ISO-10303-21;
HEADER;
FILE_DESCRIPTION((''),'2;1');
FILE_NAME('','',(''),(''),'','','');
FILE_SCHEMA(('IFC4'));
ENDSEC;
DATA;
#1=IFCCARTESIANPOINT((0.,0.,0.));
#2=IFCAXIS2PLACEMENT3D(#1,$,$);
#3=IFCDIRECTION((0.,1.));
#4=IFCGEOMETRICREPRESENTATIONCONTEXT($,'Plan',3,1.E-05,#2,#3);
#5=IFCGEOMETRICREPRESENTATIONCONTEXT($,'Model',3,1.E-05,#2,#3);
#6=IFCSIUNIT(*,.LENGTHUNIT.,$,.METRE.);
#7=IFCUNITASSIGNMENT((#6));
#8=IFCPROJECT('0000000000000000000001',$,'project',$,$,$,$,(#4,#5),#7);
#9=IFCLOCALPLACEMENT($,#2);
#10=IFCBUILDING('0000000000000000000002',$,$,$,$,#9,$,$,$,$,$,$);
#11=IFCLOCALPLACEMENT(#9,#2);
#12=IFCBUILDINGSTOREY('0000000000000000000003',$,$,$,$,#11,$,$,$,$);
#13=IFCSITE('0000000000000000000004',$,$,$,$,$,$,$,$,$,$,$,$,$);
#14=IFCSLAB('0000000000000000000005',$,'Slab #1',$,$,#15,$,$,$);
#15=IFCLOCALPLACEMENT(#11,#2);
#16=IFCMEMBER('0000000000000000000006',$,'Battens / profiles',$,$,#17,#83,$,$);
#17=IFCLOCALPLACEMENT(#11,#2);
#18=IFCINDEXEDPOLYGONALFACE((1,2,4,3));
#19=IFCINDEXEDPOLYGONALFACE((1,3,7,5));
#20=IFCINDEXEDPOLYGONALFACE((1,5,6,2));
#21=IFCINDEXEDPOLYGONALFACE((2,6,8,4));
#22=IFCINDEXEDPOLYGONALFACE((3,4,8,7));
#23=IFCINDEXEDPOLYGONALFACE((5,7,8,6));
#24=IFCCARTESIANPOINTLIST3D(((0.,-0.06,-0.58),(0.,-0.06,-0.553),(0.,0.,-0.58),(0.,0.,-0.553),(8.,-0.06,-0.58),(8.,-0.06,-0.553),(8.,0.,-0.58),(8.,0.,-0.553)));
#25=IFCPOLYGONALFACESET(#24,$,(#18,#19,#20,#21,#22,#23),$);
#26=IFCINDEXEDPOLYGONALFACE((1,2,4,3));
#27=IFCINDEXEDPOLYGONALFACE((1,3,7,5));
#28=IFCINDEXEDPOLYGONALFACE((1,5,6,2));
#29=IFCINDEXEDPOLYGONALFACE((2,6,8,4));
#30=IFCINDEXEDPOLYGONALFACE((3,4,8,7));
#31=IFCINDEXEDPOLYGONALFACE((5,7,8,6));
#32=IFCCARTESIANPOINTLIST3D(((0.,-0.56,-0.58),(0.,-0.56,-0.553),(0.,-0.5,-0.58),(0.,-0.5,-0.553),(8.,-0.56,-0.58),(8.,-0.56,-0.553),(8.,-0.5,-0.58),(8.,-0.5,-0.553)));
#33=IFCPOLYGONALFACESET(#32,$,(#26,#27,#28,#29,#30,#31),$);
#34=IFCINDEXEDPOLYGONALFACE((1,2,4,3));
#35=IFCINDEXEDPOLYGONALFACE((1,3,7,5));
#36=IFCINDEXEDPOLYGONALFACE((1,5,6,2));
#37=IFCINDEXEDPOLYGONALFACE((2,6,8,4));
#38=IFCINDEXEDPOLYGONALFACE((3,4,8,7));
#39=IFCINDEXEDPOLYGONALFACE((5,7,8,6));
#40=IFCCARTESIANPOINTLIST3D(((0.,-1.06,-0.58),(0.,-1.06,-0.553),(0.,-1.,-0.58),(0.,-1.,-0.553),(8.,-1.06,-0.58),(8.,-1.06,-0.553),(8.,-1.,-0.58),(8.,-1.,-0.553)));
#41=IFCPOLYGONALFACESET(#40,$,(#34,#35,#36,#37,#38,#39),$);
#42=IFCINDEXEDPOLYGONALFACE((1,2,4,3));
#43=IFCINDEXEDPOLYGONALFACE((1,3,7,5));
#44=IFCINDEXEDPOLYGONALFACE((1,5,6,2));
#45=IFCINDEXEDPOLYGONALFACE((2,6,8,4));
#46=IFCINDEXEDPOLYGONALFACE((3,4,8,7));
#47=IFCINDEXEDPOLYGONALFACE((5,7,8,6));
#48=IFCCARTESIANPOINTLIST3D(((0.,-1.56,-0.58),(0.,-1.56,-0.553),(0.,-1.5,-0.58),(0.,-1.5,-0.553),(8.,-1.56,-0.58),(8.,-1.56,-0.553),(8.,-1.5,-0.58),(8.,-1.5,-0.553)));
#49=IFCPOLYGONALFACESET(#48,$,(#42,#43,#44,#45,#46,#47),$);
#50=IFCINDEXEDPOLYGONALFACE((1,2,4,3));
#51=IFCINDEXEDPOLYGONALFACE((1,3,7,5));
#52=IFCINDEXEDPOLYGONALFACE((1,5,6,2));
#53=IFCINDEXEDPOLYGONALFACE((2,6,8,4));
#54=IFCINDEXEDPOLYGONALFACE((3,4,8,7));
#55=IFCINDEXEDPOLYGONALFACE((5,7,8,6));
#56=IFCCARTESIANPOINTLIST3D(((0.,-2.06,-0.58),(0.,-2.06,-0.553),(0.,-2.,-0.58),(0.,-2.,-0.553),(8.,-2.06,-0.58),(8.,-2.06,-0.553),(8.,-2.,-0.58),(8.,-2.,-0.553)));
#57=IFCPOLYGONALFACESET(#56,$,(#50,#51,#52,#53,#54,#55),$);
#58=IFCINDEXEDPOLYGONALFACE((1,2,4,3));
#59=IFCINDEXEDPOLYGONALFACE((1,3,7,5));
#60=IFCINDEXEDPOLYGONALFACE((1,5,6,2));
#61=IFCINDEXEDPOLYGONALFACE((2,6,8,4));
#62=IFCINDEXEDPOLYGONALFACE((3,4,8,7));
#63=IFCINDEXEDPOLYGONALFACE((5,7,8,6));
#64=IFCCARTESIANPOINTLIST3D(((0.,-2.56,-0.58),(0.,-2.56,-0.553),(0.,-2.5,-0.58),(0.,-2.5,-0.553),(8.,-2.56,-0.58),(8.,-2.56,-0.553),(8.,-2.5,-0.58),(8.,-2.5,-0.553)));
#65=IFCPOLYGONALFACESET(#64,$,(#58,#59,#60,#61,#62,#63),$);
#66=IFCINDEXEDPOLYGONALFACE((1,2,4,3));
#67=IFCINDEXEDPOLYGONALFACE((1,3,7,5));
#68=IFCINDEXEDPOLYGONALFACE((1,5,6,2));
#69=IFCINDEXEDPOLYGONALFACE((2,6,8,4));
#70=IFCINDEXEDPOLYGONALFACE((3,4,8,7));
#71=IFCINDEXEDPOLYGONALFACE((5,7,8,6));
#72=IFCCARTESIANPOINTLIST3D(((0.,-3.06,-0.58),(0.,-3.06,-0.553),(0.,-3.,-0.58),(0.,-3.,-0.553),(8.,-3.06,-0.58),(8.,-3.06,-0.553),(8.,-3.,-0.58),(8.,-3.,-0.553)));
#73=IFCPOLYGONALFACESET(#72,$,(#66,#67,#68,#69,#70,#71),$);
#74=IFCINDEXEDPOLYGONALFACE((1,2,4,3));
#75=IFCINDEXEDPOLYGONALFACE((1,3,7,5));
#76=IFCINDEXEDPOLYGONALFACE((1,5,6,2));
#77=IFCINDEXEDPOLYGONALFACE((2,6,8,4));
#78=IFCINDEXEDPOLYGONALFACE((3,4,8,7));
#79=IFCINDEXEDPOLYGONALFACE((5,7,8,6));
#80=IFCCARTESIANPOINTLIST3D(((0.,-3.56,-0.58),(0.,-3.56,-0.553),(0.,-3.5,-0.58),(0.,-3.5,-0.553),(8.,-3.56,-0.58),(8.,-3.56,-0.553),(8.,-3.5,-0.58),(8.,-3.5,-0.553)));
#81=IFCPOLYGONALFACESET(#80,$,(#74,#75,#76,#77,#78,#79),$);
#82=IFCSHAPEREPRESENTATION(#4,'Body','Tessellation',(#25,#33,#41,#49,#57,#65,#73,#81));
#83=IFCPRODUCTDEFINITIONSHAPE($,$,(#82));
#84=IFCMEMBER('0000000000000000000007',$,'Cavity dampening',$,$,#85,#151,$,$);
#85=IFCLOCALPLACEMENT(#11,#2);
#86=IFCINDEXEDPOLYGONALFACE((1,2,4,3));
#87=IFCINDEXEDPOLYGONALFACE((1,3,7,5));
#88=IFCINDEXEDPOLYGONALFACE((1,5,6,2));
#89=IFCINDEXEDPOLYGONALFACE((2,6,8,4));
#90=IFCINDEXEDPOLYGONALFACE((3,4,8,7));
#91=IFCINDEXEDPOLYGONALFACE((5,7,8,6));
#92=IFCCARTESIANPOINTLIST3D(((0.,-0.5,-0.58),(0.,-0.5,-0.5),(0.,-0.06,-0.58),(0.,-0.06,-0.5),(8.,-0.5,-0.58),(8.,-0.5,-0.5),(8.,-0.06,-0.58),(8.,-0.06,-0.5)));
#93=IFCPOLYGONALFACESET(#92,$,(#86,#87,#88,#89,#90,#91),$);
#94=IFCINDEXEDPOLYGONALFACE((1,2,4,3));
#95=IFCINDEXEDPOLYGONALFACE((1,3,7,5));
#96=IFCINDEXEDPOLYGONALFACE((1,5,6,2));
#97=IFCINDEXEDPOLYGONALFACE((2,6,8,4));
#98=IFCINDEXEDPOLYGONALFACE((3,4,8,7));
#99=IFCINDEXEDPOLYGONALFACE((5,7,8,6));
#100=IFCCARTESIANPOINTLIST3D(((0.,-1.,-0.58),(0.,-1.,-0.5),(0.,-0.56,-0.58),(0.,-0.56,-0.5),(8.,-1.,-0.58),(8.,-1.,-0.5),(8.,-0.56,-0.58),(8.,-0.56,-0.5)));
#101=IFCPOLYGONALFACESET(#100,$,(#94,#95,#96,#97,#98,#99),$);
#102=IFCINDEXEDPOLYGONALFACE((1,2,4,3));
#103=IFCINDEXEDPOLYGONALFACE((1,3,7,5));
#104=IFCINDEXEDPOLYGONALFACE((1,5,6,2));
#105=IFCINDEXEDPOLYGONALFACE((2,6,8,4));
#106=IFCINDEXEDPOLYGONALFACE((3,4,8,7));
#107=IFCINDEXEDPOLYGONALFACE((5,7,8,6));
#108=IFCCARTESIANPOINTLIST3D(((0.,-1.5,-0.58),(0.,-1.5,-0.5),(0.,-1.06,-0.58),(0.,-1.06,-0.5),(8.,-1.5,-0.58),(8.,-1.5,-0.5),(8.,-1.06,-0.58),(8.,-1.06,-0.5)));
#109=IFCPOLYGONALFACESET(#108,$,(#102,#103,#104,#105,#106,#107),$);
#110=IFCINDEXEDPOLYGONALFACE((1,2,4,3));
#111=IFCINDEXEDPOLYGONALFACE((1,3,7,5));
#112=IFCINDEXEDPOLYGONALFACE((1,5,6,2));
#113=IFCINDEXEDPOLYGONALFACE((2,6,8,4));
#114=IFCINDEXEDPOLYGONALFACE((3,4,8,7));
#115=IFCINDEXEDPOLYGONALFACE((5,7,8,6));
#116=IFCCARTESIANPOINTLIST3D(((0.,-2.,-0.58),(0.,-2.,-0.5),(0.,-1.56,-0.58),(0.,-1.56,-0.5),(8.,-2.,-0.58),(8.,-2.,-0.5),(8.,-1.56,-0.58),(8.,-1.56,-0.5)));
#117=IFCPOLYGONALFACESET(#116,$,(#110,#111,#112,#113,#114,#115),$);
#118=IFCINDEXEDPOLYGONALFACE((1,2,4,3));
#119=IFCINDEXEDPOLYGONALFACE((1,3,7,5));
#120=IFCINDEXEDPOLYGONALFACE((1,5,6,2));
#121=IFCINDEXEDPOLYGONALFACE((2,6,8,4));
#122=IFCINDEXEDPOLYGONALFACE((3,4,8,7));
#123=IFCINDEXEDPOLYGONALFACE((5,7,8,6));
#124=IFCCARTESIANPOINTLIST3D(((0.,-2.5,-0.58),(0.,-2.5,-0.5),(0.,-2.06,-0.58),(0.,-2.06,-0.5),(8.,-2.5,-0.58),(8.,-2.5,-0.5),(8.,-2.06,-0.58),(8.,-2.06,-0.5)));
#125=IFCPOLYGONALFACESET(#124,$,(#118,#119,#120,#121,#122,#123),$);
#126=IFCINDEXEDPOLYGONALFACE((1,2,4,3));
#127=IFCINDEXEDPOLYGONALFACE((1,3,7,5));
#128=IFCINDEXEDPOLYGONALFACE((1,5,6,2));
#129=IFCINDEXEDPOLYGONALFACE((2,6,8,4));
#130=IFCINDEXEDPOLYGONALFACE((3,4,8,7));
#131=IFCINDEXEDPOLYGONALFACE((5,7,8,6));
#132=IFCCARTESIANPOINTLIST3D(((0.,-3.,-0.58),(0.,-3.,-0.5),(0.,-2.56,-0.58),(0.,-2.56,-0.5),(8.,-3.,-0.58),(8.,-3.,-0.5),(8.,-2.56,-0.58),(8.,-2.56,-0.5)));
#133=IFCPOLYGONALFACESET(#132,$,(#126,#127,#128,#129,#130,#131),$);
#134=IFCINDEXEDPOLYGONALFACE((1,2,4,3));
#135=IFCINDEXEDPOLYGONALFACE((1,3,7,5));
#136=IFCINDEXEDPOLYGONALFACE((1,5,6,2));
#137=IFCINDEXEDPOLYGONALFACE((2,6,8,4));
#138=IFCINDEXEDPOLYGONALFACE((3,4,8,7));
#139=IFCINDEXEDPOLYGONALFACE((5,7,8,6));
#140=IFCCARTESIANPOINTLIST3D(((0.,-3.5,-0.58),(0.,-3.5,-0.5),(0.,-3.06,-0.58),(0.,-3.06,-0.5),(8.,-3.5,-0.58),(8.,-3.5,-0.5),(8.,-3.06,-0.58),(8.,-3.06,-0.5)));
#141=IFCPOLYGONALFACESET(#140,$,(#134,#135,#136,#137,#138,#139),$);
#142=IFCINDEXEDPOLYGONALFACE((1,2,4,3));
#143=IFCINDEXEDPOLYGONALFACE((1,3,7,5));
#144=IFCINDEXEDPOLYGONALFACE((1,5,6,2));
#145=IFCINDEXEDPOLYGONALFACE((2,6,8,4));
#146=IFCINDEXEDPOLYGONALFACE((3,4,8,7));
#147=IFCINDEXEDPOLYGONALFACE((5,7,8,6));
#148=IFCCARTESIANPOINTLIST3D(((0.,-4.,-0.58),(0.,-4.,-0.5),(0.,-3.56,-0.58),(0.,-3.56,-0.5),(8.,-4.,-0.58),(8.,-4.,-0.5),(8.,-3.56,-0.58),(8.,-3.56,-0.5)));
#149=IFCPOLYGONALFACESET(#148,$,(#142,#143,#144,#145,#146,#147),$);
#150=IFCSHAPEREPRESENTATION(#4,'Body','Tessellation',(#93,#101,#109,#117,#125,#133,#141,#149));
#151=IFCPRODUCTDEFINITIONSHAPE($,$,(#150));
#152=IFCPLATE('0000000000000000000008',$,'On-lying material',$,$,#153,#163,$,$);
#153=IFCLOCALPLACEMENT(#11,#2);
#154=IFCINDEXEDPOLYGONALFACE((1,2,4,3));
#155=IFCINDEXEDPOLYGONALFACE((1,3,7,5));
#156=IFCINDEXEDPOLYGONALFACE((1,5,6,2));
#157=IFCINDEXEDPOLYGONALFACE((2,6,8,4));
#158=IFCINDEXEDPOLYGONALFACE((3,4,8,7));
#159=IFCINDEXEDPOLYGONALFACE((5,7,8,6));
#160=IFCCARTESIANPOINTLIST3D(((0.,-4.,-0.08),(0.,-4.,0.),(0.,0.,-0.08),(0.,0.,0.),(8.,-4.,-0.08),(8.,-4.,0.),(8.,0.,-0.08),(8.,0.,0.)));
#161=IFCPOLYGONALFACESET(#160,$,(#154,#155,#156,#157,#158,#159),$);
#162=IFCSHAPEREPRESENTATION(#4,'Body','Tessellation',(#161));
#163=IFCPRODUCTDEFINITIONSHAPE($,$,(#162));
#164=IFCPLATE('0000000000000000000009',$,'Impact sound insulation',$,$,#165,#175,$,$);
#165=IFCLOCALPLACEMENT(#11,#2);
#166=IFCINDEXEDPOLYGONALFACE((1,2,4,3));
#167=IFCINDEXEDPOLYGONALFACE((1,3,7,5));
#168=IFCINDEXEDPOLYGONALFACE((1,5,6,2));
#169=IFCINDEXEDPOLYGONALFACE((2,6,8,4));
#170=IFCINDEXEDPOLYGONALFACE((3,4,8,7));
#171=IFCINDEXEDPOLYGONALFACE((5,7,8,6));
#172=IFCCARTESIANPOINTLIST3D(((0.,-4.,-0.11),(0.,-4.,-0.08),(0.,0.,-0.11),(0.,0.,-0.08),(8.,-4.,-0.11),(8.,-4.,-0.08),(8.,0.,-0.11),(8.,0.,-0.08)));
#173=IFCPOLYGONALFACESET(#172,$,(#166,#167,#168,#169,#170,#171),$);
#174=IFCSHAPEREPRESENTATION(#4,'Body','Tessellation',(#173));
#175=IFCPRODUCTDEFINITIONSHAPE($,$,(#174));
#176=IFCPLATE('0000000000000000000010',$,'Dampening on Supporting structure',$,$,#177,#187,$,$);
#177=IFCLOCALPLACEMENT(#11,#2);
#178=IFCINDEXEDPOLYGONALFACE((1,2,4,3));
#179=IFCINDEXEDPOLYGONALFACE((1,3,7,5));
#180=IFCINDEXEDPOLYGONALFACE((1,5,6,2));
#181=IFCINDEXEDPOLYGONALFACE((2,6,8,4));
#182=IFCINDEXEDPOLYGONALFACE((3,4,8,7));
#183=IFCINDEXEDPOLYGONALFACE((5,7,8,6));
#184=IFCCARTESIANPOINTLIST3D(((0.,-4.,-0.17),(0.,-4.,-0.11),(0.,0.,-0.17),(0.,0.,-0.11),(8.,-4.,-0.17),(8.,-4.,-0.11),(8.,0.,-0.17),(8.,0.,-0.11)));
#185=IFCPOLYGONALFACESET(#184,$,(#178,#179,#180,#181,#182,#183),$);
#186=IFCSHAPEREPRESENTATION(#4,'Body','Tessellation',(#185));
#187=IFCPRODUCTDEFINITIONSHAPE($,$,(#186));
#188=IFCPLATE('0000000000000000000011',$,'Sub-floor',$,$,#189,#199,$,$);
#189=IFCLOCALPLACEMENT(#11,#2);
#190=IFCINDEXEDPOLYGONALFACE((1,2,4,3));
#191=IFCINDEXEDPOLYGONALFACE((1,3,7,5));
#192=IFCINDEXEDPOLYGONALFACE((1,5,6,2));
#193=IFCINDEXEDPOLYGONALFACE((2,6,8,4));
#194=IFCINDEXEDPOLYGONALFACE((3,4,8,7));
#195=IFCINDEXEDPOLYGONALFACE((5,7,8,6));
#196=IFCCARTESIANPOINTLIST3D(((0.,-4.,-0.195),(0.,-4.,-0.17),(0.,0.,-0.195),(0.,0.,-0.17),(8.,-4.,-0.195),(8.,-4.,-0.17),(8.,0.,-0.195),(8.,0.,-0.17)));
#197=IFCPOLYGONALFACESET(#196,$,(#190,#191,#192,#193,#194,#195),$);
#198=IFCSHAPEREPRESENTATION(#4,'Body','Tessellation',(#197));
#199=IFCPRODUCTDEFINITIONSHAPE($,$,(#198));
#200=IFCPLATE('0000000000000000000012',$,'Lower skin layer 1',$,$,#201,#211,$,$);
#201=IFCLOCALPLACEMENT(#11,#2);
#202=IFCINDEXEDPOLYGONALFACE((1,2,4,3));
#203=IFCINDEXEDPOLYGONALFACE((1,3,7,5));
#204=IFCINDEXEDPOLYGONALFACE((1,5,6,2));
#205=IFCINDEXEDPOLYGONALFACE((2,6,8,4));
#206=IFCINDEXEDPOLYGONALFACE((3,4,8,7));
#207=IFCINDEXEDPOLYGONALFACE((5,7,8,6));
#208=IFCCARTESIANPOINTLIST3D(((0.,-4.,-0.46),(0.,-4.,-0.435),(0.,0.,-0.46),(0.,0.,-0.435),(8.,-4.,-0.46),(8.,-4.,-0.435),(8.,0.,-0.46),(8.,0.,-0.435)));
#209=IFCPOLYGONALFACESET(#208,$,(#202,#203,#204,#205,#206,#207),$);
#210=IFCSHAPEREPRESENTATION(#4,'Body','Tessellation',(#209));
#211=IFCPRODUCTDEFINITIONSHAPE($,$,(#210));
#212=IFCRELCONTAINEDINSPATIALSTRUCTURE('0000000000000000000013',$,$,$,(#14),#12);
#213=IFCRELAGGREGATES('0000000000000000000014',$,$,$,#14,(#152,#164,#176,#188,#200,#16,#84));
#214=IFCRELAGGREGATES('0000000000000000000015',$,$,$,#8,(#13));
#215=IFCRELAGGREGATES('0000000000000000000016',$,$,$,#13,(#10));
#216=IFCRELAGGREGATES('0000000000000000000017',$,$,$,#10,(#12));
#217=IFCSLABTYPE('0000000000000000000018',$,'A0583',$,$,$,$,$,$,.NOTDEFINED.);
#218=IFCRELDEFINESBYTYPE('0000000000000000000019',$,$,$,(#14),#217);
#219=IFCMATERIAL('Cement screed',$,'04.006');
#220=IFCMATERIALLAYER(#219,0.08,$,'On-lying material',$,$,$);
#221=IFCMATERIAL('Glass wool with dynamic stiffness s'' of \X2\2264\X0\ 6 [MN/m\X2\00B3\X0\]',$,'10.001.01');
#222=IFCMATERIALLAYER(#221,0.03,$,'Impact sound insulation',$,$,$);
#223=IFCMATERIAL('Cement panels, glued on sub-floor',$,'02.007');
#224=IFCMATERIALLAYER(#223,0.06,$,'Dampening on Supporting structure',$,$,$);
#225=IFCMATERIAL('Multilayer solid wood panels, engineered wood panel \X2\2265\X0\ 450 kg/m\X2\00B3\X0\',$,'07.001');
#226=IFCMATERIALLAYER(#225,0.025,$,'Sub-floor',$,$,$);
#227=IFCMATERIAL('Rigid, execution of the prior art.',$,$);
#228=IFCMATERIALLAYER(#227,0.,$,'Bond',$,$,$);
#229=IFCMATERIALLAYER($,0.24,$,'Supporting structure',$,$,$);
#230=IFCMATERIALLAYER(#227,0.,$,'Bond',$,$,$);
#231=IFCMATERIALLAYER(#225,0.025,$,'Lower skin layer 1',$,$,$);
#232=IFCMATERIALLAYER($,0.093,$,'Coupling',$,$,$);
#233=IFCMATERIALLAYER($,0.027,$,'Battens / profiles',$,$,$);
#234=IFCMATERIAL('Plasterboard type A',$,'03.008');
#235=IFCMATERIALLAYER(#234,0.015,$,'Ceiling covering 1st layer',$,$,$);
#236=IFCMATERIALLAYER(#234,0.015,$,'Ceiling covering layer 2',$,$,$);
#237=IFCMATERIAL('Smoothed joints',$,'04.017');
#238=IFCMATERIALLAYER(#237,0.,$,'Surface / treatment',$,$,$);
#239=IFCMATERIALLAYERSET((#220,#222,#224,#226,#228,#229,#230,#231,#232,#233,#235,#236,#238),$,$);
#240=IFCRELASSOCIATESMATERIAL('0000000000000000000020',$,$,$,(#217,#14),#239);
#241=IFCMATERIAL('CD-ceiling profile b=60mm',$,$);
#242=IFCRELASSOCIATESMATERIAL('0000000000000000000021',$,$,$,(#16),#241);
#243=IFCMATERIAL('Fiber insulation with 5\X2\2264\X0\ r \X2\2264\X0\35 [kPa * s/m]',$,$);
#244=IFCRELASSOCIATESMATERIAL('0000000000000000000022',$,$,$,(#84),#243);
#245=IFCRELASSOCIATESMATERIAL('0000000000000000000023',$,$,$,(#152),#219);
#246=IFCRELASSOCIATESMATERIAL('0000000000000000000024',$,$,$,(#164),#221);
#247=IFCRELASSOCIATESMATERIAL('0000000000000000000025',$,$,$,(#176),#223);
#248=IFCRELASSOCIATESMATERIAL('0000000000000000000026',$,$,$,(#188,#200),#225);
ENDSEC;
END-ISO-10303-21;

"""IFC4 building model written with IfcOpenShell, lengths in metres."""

from ifc_helpers import new_model, si_unit, direction, frame, frame_2d, origin, origin_with_axes, place, context, project, spatial, rectangle, extrude, material, layer, layer_set, type_object, element, aggregate, save


model = new_model("IFC4")

# Units and contexts
plan_context = context("Plan", 3, precision=1e-05, world=origin(), true_north=direction((0.0, 1.0)))
model_context = context("Model", 3, precision=1e-05, world=origin(), true_north=direction((0.0, 1.0)))
ifc_project = project(units=[si_unit("LENGTHUNIT", "METRE")], contexts=[plan_context, model_context])

# Site, building, storey
site = spatial("IfcSite", under=ifc_project)
building_placement = place(None, origin())
building = spatial("IfcBuilding", under=site, at=building_placement)
storey_placement = place(building_placement, origin())
storey = spatial("IfcBuildingStorey", under=building, at=storey_placement)

# Slab, members, plates
ifc_material_1 = material(Name="Cement screed", Category="04.006")
ifc_layer_1 = layer(ifc_material_1, 0.08, Name="On-lying material")
ifc_material_2 = material(Name="Glass wool with dynamic stiffness s' of ≤ 6 [MN/m³]", Category="10.001.01")
ifc_layer_2 = layer(ifc_material_2, 0.03, Name="Impact sound insulation")
ifc_material_3 = material(Name="Cement panels, glued on sub-floor", Category="02.007")
ifc_layer_3 = layer(ifc_material_3, 0.06, Name="Dampening on Supporting structure")
ifc_material_4 = material(Name="Multilayer solid wood panels, engineered wood panel ≥ 450 kg/m³", Category="07.001")
ifc_layer_4 = layer(ifc_material_4, 0.025, Name="Sub-floor")
ifc_material_5 = material(Name="Rigid, execution of the prior art.")
ifc_layer_5 = layer(ifc_material_5, 0.0, Name="Bond")
ifc_layer_6 = layer(None, 0.24, Name="Supporting structure")
ifc_layer_7 = layer(ifc_material_5, 0.0, Name="Bond")
ifc_layer_8 = layer(ifc_material_4, 0.025, Name="Lower skin layer 1")
ifc_layer_9 = layer(None, 0.093, Name="Coupling")
ifc_layer_10 = layer(None, 0.027, Name="Battens / profiles")
ifc_material_6 = material(Name="Plasterboard type A", Category="03.008")
ifc_layer_11 = layer(ifc_material_6, 0.015, Name="Ceiling covering 1st layer")
ifc_layer_12 = layer(ifc_material_6, 0.015, Name="Ceiling covering layer 2")
ifc_material_7 = material(Name="Smoothed joints", Category="04.017")
ifc_layer_13 = layer(ifc_material_7, 0.0, Name="Surface / treatment")
ifc_layer_set = layer_set([ifc_layer_1, ifc_layer_2, ifc_layer_3, ifc_layer_4, ifc_layer_5, ifc_layer_6, ifc_layer_7, ifc_layer_8, ifc_layer_9, ifc_layer_10, ifc_layer_11, ifc_layer_12, ifc_layer_13])
slab_type = type_object("IfcSlabType", Name="A0583", PredefinedType="NOTDEFINED", material=ifc_layer_set)
slab_placement = place(None, frame((0.0, 0.0, 0.0), z_axis=(0.0, 0.0, -1.0), x_axis=(1.0, 0.0, 0.0)))
slab = element("IfcSlab", 1, at=slab_placement, inside=storey, type_object=slab_type, material=ifc_layer_set, Name="Slab #1")
ifc_material_8 = material(Name="Fiber insulation with 5≤ r ≤35 [kPa * s/m]")
ifc_material_9 = material(Name="CD-ceiling profile b=60mm")
member_1_placement = place(slab_placement, origin())
member_1 = element("IfcMember", 2, at=member_1_placement, material=ifc_material_9, Name="Battens / profiles", context=plan_context, shape_type="SweptSolid", body=[
    extrude(rectangle(XDim=0.06, YDim=0.027, at=frame_2d((0.03, 0.0135), x_axis=(1.0, 0.0))), frame((0.0, 0.0, 0.553), z_axis=(1.0, 0.0, 0.0), x_axis=(0.0, 1.0, 0.0)), (0.0, 0.0, 1.0), 8.0),
    extrude(rectangle(XDim=0.06, YDim=0.027, at=frame_2d((0.03, 0.0135), x_axis=(1.0, 0.0))), frame((0.0, 0.5, 0.553), z_axis=(1.0, 0.0, 0.0), x_axis=(0.0, 1.0, 0.0)), (0.0, 0.0, 1.0), 8.0),
    extrude(rectangle(XDim=0.06, YDim=0.027, at=frame_2d((0.03, 0.0135), x_axis=(1.0, 0.0))), frame((0.0, 1.0, 0.553), z_axis=(1.0, 0.0, 0.0), x_axis=(0.0, 1.0, 0.0)), (0.0, 0.0, 1.0), 8.0),
    extrude(rectangle(XDim=0.06, YDim=0.027, at=frame_2d((0.03, 0.0135), x_axis=(1.0, 0.0))), frame((0.0, 1.5, 0.553), z_axis=(1.0, 0.0, 0.0), x_axis=(0.0, 1.0, 0.0)), (0.0, 0.0, 1.0), 8.0),
    extrude(rectangle(XDim=0.06, YDim=0.027, at=frame_2d((0.03, 0.0135), x_axis=(1.0, 0.0))), frame((0.0, 2.0, 0.553), z_axis=(1.0, 0.0, 0.0), x_axis=(0.0, 1.0, 0.0)), (0.0, 0.0, 1.0), 8.0),
    extrude(rectangle(XDim=0.06, YDim=0.027, at=frame_2d((0.03, 0.0135), x_axis=(1.0, 0.0))), frame((0.0, 2.5, 0.553), z_axis=(1.0, 0.0, 0.0), x_axis=(0.0, 1.0, 0.0)), (0.0, 0.0, 1.0), 8.0),
    extrude(rectangle(XDim=0.06, YDim=0.027, at=frame_2d((0.03, 0.0135), x_axis=(1.0, 0.0))), frame((0.0, 3.0, 0.553), z_axis=(1.0, 0.0, 0.0), x_axis=(0.0, 1.0, 0.0)), (0.0, 0.0, 1.0), 8.0),
    extrude(rectangle(XDim=0.06, YDim=0.027, at=frame_2d((0.03, 0.0135), x_axis=(1.0, 0.0))), frame((0.0, 3.5, 0.553), z_axis=(1.0, 0.0, 0.0), x_axis=(0.0, 1.0, 0.0)), (0.0, 0.0, 1.0), 8.0),
])
member_2_placement = place(slab_placement, origin())
member_2 = element("IfcMember", 3, at=member_2_placement, material=ifc_material_8, Name="Cavity dampening", context=plan_context, shape_type="SweptSolid", body=[
    extrude(rectangle(XDim=0.44, YDim=0.08, at=frame_2d((0.22, 0.04), x_axis=(1.0, 0.0))), frame((0.0, 0.06, 0.5), z_axis=(1.0, 0.0, 0.0), x_axis=(0.0, 1.0, 0.0)), (0.0, 0.0, 1.0), 8.0),
    extrude(rectangle(XDim=0.44, YDim=0.08, at=frame_2d((0.22, 0.04), x_axis=(1.0, 0.0))), frame((0.0, 0.56, 0.5), z_axis=(1.0, 0.0, 0.0), x_axis=(0.0, 1.0, 0.0)), (0.0, 0.0, 1.0), 8.0),
    extrude(rectangle(XDim=0.44, YDim=0.08, at=frame_2d((0.22, 0.04), x_axis=(1.0, 0.0))), frame((0.0, 1.06, 0.5), z_axis=(1.0, 0.0, 0.0), x_axis=(0.0, 1.0, 0.0)), (0.0, 0.0, 1.0), 8.0),
    extrude(rectangle(XDim=0.44, YDim=0.08, at=frame_2d((0.22, 0.04), x_axis=(1.0, 0.0))), frame((0.0, 1.56, 0.5), z_axis=(1.0, 0.0, 0.0), x_axis=(0.0, 1.0, 0.0)), (0.0, 0.0, 1.0), 8.0),
    extrude(rectangle(XDim=0.44, YDim=0.08, at=frame_2d((0.22, 0.04), x_axis=(1.0, 0.0))), frame((0.0, 2.06, 0.5), z_axis=(1.0, 0.0, 0.0), x_axis=(0.0, 1.0, 0.0)), (0.0, 0.0, 1.0), 8.0),
    extrude(rectangle(XDim=0.44, YDim=0.08, at=frame_2d((0.22, 0.04), x_axis=(1.0, 0.0))), frame((0.0, 2.56, 0.5), z_axis=(1.0, 0.0, 0.0), x_axis=(0.0, 1.0, 0.0)), (0.0, 0.0, 1.0), 8.0),
    extrude(rectangle(XDim=0.44, YDim=0.08, at=frame_2d((0.22, 0.04), x_axis=(1.0, 0.0))), frame((0.0, 3.06, 0.5), z_axis=(1.0, 0.0, 0.0), x_axis=(0.0, 1.0, 0.0)), (0.0, 0.0, 1.0), 8.0),
    extrude(rectangle(XDim=0.44, YDim=0.08, at=frame_2d((0.22, 0.04), x_axis=(1.0, 0.0))), frame((0.0, 3.56, 0.5), z_axis=(1.0, 0.0, 0.0), x_axis=(0.0, 1.0, 0.0)), (0.0, 0.0, 1.0), 8.0),
])
plate_1_placement = place(slab_placement, origin())
plate_1 = element("IfcPlate", 4, at=plate_1_placement, material=ifc_material_1, Name="On-lying material", context=plan_context, shape_type="SweptSolid", body=[
    extrude(rectangle(XDim=8.0, YDim=4.0, at=frame_2d((4.0, 2.0), x_axis=(1.0, 0.0))), origin_with_axes(), (0.0, 0.0, 1.0), 0.08),
])
plate_2_placement = place(slab_placement, origin())
plate_2 = element("IfcPlate", 5, at=plate_2_placement, material=ifc_material_2, Name="Impact sound insulation", context=plan_context, shape_type="SweptSolid", body=[
    extrude(rectangle(XDim=8.0, YDim=4.0, at=frame_2d((4.0, 2.0), x_axis=(1.0, 0.0))), frame((0.0, 0.0, 0.08), z_axis=(0.0, 0.0, 1.0), x_axis=(1.0, 0.0, 0.0)), (0.0, 0.0, 1.0), 0.03),
])
plate_3_placement = place(slab_placement, origin())
plate_3 = element("IfcPlate", 6, at=plate_3_placement, material=ifc_material_3, Name="Dampening on Supporting structure", context=plan_context, shape_type="SweptSolid", body=[
    extrude(rectangle(XDim=8.0, YDim=4.0, at=frame_2d((4.0, 2.0), x_axis=(1.0, 0.0))), frame((0.0, 0.0, 0.11), z_axis=(0.0, 0.0, 1.0), x_axis=(1.0, 0.0, 0.0)), (0.0, 0.0, 1.0), 0.06),
])
plate_4_placement = place(slab_placement, origin())
plate_4 = element("IfcPlate", 7, at=plate_4_placement, material=ifc_material_4, Name="Sub-floor", context=plan_context, shape_type="SweptSolid", body=[
    extrude(rectangle(XDim=8.0, YDim=4.0, at=frame_2d((4.0, 2.0), x_axis=(1.0, 0.0))), frame((0.0, 0.0, 0.17), z_axis=(0.0, 0.0, 1.0), x_axis=(1.0, 0.0, 0.0)), (0.0, 0.0, 1.0), 0.025),
])
plate_5_placement = place(slab_placement, origin())
plate_5 = element("IfcPlate", 8, at=plate_5_placement, material=ifc_material_4, Name="Lower skin layer 1", context=plan_context, shape_type="SweptSolid", body=[
    extrude(rectangle(XDim=8.0, YDim=4.0, at=frame_2d((4.0, 2.0), x_axis=(1.0, 0.0))), frame((0.0, 0.0, 0.435), z_axis=(0.0, 0.0, 1.0), x_axis=(1.0, 0.0, 0.0)), (0.0, 0.0, 1.0), 0.025),
])
aggregate(slab, [plate_1, plate_2, plate_3, plate_4, plate_5, member_1, member_2])

save(model, "model.ifc")
